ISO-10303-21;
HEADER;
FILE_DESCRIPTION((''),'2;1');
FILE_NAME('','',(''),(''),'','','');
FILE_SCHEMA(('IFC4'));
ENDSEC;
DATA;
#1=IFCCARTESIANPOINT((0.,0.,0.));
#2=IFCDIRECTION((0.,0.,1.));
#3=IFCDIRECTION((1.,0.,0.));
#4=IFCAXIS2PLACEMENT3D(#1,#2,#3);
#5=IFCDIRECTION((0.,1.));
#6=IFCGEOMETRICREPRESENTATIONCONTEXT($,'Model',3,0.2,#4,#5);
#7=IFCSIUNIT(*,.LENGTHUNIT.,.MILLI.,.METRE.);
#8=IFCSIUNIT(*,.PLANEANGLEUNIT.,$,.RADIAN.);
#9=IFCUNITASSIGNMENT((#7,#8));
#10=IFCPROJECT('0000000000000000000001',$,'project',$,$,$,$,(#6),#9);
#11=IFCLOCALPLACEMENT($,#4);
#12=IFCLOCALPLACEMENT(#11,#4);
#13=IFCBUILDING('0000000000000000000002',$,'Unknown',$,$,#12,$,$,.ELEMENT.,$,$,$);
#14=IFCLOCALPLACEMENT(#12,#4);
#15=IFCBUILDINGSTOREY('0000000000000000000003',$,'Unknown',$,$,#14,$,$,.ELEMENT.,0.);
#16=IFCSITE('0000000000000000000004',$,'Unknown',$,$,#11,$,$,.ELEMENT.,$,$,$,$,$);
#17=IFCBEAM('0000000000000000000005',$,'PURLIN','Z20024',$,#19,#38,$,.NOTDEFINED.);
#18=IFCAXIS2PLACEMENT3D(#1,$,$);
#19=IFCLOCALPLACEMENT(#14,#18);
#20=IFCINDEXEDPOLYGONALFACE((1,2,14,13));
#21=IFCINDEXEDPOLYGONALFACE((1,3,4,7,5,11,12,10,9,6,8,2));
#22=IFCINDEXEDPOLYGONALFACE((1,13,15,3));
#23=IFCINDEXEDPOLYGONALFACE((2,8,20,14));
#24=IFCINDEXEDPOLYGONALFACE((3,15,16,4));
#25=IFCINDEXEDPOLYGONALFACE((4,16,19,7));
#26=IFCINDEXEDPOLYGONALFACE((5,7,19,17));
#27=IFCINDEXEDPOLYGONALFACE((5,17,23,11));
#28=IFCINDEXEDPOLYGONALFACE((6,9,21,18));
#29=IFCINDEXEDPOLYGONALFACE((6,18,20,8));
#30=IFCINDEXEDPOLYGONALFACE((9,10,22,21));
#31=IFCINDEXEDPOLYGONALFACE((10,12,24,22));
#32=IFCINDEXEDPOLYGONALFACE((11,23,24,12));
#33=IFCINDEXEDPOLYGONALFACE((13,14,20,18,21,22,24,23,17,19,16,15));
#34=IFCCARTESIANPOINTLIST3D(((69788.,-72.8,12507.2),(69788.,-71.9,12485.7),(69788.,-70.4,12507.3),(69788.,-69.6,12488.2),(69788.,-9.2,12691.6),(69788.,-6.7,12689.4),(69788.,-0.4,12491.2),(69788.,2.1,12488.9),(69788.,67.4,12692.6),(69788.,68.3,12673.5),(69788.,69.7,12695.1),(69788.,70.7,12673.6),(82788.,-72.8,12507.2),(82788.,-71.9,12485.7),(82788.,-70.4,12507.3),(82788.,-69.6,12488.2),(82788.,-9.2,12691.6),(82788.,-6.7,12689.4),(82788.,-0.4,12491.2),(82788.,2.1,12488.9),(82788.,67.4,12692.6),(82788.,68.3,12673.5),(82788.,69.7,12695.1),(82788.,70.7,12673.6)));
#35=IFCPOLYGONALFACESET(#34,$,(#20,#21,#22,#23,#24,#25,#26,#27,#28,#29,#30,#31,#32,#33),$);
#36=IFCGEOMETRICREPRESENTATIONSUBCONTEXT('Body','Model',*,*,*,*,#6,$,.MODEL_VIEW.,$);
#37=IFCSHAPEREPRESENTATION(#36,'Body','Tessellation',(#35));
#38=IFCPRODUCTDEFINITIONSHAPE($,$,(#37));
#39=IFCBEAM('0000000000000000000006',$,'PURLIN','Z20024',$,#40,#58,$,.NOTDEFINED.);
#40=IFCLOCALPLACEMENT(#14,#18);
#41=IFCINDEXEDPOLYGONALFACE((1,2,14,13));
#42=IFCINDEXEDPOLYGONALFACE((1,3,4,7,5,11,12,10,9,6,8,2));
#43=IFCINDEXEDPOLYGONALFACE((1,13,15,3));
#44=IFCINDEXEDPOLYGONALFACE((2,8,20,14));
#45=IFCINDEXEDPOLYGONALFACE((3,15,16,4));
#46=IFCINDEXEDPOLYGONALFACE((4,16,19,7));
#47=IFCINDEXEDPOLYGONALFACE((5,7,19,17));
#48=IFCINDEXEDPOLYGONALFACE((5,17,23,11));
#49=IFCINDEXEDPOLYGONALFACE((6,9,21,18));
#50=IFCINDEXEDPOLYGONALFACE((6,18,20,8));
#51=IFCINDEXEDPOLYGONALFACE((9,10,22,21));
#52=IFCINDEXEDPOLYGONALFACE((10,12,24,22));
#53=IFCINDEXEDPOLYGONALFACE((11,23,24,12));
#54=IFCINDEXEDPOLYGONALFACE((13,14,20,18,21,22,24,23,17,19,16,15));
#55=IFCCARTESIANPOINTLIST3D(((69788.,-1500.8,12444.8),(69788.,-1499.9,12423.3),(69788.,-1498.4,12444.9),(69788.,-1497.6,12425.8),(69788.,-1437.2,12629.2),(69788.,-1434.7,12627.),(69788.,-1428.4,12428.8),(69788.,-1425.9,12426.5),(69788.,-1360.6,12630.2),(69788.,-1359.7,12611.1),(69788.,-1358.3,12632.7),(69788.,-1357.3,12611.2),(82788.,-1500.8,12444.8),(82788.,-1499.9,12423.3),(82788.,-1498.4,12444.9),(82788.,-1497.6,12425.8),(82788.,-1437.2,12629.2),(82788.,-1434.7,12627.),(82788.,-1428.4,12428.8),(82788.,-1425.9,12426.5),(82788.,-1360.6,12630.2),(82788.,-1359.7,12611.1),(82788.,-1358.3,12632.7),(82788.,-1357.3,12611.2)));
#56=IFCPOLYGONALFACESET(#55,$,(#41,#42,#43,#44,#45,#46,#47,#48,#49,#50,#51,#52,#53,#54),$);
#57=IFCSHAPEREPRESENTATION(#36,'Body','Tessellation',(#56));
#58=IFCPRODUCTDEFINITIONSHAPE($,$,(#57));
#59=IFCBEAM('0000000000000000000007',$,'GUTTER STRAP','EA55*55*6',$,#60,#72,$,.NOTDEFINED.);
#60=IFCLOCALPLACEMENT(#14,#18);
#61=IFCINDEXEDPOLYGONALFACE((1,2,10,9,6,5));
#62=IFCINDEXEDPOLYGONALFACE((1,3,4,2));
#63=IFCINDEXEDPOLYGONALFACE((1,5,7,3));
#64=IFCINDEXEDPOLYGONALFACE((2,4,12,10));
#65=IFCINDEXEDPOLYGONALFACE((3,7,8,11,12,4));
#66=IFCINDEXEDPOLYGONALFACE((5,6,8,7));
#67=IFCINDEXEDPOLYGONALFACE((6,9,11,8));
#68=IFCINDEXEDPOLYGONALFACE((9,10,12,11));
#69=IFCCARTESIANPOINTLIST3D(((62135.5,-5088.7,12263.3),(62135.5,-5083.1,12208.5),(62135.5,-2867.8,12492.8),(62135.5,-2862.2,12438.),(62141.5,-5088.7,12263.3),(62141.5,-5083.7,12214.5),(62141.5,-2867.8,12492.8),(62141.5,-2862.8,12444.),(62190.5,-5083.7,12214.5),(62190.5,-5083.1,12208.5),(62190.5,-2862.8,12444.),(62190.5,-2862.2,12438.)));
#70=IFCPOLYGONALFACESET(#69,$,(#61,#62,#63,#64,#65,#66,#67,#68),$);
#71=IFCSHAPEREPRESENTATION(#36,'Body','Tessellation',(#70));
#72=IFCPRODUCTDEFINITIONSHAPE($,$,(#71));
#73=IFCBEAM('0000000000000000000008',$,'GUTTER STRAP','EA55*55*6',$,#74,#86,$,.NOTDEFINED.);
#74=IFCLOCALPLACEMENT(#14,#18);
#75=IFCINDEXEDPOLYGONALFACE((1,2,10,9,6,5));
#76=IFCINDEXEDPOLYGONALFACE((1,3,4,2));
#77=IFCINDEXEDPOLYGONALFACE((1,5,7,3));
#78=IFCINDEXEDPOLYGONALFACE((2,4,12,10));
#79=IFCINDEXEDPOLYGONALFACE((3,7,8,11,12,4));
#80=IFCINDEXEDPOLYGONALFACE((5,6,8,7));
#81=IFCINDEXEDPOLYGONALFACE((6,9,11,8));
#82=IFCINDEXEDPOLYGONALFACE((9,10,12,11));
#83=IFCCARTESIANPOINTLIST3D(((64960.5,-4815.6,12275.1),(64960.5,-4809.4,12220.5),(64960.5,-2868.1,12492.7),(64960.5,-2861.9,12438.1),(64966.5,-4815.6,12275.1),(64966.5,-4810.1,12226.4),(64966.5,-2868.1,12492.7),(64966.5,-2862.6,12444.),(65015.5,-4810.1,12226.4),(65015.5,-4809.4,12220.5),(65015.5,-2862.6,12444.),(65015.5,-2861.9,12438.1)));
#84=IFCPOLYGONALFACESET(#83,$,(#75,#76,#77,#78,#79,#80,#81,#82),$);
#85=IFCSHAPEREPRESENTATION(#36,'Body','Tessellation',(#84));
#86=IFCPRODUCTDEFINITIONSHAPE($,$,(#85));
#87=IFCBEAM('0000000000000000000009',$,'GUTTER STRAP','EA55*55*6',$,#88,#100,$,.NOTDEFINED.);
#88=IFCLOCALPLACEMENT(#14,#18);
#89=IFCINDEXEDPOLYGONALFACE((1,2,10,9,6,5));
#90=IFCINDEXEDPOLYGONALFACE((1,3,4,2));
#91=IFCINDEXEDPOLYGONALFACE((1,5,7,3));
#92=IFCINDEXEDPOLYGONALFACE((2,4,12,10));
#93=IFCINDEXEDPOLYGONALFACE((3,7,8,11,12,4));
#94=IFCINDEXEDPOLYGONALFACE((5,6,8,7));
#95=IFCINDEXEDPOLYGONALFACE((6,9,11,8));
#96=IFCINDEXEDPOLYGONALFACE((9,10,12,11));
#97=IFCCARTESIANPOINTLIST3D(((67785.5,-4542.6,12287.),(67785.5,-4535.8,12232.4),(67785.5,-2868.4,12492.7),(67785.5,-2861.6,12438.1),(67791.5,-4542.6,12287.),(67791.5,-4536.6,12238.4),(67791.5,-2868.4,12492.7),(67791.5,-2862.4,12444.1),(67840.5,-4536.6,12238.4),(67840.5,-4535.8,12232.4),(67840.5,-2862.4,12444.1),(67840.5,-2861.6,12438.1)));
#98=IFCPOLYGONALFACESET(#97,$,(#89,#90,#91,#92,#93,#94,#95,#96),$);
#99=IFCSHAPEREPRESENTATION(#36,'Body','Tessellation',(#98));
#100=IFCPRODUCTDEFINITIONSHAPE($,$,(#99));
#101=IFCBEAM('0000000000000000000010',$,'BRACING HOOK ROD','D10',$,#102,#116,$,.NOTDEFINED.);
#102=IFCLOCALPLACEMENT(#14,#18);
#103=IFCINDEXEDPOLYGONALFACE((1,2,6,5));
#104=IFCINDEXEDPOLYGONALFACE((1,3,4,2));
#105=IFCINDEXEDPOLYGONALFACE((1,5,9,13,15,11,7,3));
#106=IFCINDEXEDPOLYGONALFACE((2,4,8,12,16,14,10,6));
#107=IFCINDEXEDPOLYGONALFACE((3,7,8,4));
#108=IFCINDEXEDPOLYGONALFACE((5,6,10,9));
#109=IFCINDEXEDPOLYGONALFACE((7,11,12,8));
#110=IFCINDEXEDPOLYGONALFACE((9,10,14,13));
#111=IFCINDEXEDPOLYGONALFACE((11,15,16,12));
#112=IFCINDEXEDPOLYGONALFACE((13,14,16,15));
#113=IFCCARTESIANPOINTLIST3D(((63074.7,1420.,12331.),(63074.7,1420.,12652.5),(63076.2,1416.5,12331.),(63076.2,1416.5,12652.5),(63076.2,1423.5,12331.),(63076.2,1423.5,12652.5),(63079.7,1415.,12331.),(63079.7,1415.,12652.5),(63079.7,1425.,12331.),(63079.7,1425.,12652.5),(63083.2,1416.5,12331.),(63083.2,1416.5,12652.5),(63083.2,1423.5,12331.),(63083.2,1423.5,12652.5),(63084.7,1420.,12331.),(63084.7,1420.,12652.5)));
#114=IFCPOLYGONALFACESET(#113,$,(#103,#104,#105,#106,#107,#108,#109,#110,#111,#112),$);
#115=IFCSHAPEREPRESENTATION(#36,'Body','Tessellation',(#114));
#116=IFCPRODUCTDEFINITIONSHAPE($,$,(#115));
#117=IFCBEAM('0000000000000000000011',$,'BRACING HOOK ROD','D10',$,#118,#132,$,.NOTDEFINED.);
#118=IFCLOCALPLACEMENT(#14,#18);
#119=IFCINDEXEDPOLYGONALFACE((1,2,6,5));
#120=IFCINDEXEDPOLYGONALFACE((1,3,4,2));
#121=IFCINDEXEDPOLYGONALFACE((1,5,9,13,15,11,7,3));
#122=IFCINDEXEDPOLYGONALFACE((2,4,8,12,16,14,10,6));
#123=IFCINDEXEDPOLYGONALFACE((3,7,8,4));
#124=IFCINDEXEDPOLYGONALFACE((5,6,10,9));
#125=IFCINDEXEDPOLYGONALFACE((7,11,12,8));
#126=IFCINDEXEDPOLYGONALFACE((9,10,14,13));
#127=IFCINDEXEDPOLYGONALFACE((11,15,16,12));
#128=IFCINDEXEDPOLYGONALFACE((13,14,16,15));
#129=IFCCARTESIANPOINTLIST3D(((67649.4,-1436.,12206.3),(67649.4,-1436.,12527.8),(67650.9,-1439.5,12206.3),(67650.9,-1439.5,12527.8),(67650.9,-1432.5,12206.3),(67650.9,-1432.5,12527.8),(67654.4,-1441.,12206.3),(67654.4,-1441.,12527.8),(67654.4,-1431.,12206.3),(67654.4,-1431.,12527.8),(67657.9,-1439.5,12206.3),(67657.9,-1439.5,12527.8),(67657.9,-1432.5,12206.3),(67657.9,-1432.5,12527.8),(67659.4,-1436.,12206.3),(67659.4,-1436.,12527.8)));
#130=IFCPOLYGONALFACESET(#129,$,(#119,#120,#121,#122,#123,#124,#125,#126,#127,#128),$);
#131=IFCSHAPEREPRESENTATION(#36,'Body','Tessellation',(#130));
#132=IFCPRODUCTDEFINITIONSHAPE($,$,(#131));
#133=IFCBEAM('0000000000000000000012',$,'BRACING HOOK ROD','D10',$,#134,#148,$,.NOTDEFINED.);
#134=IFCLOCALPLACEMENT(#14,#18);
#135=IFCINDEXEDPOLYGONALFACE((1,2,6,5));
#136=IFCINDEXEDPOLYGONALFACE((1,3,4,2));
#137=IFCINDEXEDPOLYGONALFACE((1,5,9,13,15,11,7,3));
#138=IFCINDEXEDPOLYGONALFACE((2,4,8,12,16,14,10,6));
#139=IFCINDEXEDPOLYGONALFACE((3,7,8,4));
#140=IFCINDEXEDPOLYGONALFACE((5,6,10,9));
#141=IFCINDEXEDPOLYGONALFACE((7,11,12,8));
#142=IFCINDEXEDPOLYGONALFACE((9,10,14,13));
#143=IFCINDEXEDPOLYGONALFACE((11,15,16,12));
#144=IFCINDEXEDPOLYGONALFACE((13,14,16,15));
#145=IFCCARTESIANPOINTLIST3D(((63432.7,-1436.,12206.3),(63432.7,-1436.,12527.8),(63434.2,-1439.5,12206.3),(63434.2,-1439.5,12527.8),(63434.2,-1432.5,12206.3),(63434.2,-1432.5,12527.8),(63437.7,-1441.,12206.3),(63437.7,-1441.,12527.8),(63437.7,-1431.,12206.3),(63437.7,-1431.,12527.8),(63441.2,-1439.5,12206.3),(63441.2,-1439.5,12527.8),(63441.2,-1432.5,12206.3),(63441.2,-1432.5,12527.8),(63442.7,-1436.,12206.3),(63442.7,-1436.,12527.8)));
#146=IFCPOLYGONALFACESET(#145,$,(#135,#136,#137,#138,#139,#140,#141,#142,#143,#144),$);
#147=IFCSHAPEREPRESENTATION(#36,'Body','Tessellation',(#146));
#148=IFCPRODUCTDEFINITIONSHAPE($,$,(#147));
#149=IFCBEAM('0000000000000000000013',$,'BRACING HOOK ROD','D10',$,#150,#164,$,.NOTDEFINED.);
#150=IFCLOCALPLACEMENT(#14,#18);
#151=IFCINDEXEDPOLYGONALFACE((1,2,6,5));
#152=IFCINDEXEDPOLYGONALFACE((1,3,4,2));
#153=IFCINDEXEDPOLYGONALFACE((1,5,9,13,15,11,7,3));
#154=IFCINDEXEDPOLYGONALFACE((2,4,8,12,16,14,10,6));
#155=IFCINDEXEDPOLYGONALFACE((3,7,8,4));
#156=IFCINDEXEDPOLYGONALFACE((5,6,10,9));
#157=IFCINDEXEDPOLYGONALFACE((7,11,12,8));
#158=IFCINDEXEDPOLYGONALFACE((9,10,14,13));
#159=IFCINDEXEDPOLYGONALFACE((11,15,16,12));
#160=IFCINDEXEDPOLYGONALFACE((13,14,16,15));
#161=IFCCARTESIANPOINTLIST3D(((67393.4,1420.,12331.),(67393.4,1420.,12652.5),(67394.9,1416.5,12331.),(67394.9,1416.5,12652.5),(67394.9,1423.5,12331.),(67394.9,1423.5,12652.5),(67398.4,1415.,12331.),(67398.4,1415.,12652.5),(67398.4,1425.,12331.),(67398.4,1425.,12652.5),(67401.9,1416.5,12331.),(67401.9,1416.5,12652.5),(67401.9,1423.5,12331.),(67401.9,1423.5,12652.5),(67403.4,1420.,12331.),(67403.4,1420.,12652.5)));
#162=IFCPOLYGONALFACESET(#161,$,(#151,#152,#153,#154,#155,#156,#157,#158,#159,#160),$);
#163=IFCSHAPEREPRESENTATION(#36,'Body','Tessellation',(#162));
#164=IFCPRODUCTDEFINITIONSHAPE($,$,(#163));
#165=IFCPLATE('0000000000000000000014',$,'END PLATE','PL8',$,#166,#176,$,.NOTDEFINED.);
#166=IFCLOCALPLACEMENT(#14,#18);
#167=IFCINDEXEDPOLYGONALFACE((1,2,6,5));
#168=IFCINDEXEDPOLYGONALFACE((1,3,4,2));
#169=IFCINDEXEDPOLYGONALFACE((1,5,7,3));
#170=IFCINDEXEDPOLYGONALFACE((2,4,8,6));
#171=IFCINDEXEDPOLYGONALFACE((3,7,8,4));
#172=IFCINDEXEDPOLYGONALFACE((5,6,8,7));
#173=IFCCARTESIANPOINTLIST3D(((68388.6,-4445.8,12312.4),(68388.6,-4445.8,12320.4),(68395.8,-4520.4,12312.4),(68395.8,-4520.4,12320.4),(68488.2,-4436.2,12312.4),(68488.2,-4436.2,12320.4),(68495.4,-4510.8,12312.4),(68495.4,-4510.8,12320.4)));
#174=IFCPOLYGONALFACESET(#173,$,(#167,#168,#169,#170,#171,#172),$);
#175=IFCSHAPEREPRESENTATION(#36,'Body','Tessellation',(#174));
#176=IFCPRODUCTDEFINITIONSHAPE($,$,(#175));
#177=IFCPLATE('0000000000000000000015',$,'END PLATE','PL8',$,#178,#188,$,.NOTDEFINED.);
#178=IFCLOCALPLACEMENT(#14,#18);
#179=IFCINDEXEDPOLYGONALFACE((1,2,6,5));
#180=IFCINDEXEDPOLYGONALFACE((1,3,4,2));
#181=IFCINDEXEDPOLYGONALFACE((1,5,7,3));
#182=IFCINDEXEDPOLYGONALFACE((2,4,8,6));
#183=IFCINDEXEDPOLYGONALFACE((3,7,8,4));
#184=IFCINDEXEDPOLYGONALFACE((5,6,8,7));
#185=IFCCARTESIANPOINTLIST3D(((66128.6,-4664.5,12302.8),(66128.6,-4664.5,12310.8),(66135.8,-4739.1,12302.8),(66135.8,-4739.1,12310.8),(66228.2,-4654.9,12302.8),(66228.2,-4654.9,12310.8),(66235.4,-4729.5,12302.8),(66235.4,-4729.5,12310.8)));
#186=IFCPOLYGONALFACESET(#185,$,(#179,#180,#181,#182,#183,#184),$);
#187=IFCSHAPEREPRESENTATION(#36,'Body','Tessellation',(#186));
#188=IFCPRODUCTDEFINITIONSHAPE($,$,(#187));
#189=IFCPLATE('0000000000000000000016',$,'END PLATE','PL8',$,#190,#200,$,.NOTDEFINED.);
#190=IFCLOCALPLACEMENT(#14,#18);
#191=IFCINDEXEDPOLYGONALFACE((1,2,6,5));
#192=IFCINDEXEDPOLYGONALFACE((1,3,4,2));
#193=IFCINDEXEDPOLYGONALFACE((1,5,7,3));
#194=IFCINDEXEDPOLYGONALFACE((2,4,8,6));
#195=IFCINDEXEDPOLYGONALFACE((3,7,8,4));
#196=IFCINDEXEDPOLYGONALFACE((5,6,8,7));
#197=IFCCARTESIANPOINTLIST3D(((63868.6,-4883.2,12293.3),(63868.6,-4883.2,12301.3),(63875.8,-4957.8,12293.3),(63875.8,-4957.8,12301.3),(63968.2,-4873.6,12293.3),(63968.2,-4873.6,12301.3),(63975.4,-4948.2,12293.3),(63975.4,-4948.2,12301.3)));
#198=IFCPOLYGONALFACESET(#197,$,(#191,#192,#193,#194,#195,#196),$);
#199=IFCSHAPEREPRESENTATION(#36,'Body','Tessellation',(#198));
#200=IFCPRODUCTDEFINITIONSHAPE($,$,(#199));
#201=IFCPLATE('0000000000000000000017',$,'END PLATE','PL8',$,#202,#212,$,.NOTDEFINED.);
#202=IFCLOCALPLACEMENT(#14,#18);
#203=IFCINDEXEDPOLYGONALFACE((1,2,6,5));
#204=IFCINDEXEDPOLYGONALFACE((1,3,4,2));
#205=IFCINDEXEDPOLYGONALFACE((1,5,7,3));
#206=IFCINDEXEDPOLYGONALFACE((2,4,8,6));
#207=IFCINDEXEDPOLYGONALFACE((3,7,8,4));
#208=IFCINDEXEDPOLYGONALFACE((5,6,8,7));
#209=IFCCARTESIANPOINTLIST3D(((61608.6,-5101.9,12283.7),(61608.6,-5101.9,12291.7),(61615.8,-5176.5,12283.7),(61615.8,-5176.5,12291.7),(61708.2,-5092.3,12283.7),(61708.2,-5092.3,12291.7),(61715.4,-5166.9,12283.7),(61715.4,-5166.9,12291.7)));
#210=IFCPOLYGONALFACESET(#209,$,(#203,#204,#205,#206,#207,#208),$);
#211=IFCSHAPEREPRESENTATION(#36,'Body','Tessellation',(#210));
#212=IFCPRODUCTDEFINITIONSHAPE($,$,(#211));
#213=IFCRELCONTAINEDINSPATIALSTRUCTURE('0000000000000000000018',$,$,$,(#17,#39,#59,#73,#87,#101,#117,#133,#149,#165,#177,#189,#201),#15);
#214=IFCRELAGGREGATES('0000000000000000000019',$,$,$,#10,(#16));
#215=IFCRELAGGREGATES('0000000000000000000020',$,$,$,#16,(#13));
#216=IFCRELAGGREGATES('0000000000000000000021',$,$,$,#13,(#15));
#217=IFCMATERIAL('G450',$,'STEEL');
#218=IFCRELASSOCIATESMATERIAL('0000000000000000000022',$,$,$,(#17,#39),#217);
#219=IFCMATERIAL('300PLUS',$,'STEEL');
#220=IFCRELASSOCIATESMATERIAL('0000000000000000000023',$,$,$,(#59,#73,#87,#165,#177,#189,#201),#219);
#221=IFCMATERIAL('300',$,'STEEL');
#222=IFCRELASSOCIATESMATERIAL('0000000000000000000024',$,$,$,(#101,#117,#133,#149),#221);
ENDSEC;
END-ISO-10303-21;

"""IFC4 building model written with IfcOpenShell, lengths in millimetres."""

from ifc_helpers import new_model, si_unit, direction, frame, origin_with_axes, place, context, subcontext, project, spatial, line, indexed_curve, outline, extrude, material, element, save


model = new_model("IFC4")

# Units and contexts
model_context = context("Model", 3, precision=0.2, world=origin_with_axes(), true_north=direction((0.0, 1.0)))
body_context = subcontext(model_context, "Body", "Model", "MODEL_VIEW")
ifc_project = project(units=[si_unit("LENGTHUNIT", "METRE", prefix="MILLI"), si_unit("PLANEANGLEUNIT", "RADIAN")], contexts=[model_context])

# Site, building, storey
site_placement = place(None, origin_with_axes())
site = spatial("IfcSite", under=ifc_project, at=site_placement, Name="Unknown", CompositionType="ELEMENT")
building_placement = place(site_placement, origin_with_axes())
building = spatial("IfcBuilding", under=site, at=building_placement, Name="Unknown", CompositionType="ELEMENT")
storey_placement = place(building_placement, origin_with_axes())
storey = spatial("IfcBuildingStorey", under=building, at=storey_placement, Name="Unknown", CompositionType="ELEMENT", Elevation=0.0)

# Shared definitions
ifc_material_1 = material(Name="300PLUS", Category="STEEL")

# Beams
ifc_material_2 = material(Name="G450", Category="STEEL")
for number, where, z_axis, x_axis, name in (
    (1, (69788.0, -3.6, 12590.3), (0.0, -0.999048, -0.043619), (1.0, 0.0, 0.0), "PURLIN"),
    (2, (69788.0, -1431.6, 12527.9), (0.0, -0.999048, -0.043619), (1.0, 0.0, 0.0), "PURLIN"),
):
    element("IfcBeam", number, at=place(storey_placement, frame(where, z_axis=z_axis, x_axis=x_axis)), inside=storey, material=ifc_material_2, Name=name, Description="Z20024", PredefinedType="NOTDEFINED", context=body_context, shape_type="SolidModel", body=[
        extrude(outline(indexed_curve([(72.8, -101.5), (72.8, -80.0), (70.4, -80.0), (70.4, -99.1), (1.2, -99.1), (1.2, 101.5), (-77.8, 101.5), (-77.8, 80.0), (-75.4, 80.0), (-75.4, 99.1), (-1.2, 99.1), (-1.2, -101.5)], segments=[line(1, 2, 3, 4, 5, 6, 7, 8, 9, 10, 11, 12, 1)])), frame((0.0, 0.0, 0.0), z_axis=(-1.0, 0.0, 0.0), x_axis=(0.0, 0.0, 1.0)), (0.0, 0.0, -1.0), 13000.0),
    ])
beam_1_placement = place(storey_placement, frame((62163.0, -2865.0, 12465.4), z_axis=(0.0, -0.102789, 0.994703), x_axis=(0.0, -0.994703, -0.102789)))
element("IfcBeam", 3, at=beam_1_placement, inside=storey, material=ifc_material_1, Name="GUTTER STRAP", Description="EA55*55*6", PredefinedType="NOTDEFINED", context=body_context, shape_type="SolidModel", body=[
    extrude(outline(indexed_curve([(-27.5, -27.5), (27.5, -27.5), (27.5, -21.5), (-21.5, -21.5), (-21.5, 27.5), (-27.5, 27.5)], segments=[line(1, 2, 3, 4, 5, 6, 1)])), frame((0.0, 0.0, 0.0), z_axis=(-1.0, 0.0, 0.0), x_axis=(0.0, 0.0, 1.0)), (0.0, 0.0, -1.0), 2232.7),
])
beam_2_placement = place(storey_placement, frame((64988.0, -2865.0, 12465.4), z_axis=(0.0, -0.111042, 0.993816), x_axis=(0.0, -0.993816, -0.111042)))
element("IfcBeam", 4, at=beam_2_placement, inside=storey, material=ifc_material_1, Name="GUTTER STRAP", Description="EA55*55*6", PredefinedType="NOTDEFINED", context=body_context, shape_type="SolidModel", body=[
    extrude(outline(indexed_curve([(-27.5, -27.5), (27.5, -27.5), (27.5, -21.5), (-21.5, -21.5), (-21.5, 27.5), (-27.5, 27.5)], segments=[line(1, 2, 3, 4, 5, 6, 1)])), frame((0.0, 0.0, 0.0), z_axis=(-1.0, 0.0, 0.0), x_axis=(0.0, 0.0, 1.0)), (0.0, 0.0, -1.0), 1959.6),
])
beam_3_placement = place(storey_placement, frame((67813.0, -2865.0, 12465.4), z_axis=(0.0, -0.121948, 0.992537), x_axis=(0.0, -0.992537, -0.121948)))
element("IfcBeam", 5, at=beam_3_placement, inside=storey, material=ifc_material_1, Name="GUTTER STRAP", Description="EA55*55*6", PredefinedType="NOTDEFINED", context=body_context, shape_type="SolidModel", body=[
    extrude(outline(indexed_curve([(-27.5, -27.5), (27.5, -27.5), (27.5, -21.5), (-21.5, -21.5), (-21.5, 27.5), (-27.5, 27.5)], segments=[line(1, 2, 3, 4, 5, 6, 1)])), frame((0.0, 0.0, 0.0), z_axis=(-1.0, 0.0, 0.0), x_axis=(0.0, 0.0, 1.0)), (0.0, 0.0, -1.0), 1686.8),
])
ifc_material_3 = material(Name="300", Category="STEEL")
for number, where, z_axis, x_axis, name in (
    (6, (63079.7, 1420.0, 12652.5), (1.0, 0.0, 0.0), (0.0, 0.0, -1.0), "BRACING HOOK ROD"),
    (7, (67654.4, -1436.0, 12527.8), (1.0, 0.0, 0.0), (0.0, 0.0, -1.0), "BRACING HOOK ROD"),
    (8, (63437.7, -1436.0, 12527.8), (1.0, 0.0, 0.0), (0.0, 0.0, -1.0), "BRACING HOOK ROD"),
    (9, (67398.4, 1420.0, 12652.5), (1.0, 0.0, 0.0), (0.0, 0.0, -1.0), "BRACING HOOK ROD"),
):
    element("IfcBeam", number, at=place(storey_placement, frame(where, z_axis=z_axis, x_axis=x_axis)), inside=storey, material=ifc_material_3, Name=name, Description="D10", PredefinedType="NOTDEFINED", context=body_context, shape_type="SolidModel", body=[
        extrude(outline(indexed_curve([(5.0, 0.0), (3.5, 3.5), (0.0, 5.0), (-3.5, 3.5), (-5.0, 0.0), (-3.5, -3.5), (0.0, -5.0), (3.5, -3.5)], segments=[line(1, 2, 3, 4, 5, 6, 7, 8, 1)])), frame((0.0, 0.0, 0.0), z_axis=(-1.0, 0.0, 0.0), x_axis=(0.0, 0.0, 1.0)), (0.0, 0.0, -1.0), 321.5),
    ])

# Plates
for number, where, z_axis, x_axis, name in (
    (10, (68395.8, -4520.4, 12316.4), (0.0, 0.0, 1.0), (0.995387, 0.095941, 0.0), "END PLATE"),
    (11, (66135.8, -4739.1, 12306.8), (0.0, 0.0, 1.0), (0.995387, 0.095941, 0.0), "END PLATE"),
    (12, (63875.8, -4957.8, 12297.3), (0.0, 0.0, 1.0), (0.995387, 0.095941, 0.0), "END PLATE"),
    (13, (61615.8, -5176.5, 12287.7), (0.0, 0.0, 1.0), (0.995387, 0.095941, 0.0), "END PLATE"),
):
    element("IfcPlate", number, at=place(storey_placement, frame(where, z_axis=z_axis, x_axis=x_axis)), inside=storey, material=ifc_material_1, Name=name, Description="PL8", PredefinedType="NOTDEFINED", context=body_context, shape_type="SolidModel", body=[
        extrude(outline(indexed_curve([(0.0, 0.0), (100.1, 0.0), (100.1, 74.9), (0.0, 74.9)], segments=[line(1, 2, 3, 4, 1)])), frame((0.0, 0.0, 4.0), z_axis=(0.0, 0.0, 1.0), x_axis=(1.0, 0.0, 0.0)), (0.0, 0.0, -1.0), 8.0),
    ])

save(model, "model.ifc")
